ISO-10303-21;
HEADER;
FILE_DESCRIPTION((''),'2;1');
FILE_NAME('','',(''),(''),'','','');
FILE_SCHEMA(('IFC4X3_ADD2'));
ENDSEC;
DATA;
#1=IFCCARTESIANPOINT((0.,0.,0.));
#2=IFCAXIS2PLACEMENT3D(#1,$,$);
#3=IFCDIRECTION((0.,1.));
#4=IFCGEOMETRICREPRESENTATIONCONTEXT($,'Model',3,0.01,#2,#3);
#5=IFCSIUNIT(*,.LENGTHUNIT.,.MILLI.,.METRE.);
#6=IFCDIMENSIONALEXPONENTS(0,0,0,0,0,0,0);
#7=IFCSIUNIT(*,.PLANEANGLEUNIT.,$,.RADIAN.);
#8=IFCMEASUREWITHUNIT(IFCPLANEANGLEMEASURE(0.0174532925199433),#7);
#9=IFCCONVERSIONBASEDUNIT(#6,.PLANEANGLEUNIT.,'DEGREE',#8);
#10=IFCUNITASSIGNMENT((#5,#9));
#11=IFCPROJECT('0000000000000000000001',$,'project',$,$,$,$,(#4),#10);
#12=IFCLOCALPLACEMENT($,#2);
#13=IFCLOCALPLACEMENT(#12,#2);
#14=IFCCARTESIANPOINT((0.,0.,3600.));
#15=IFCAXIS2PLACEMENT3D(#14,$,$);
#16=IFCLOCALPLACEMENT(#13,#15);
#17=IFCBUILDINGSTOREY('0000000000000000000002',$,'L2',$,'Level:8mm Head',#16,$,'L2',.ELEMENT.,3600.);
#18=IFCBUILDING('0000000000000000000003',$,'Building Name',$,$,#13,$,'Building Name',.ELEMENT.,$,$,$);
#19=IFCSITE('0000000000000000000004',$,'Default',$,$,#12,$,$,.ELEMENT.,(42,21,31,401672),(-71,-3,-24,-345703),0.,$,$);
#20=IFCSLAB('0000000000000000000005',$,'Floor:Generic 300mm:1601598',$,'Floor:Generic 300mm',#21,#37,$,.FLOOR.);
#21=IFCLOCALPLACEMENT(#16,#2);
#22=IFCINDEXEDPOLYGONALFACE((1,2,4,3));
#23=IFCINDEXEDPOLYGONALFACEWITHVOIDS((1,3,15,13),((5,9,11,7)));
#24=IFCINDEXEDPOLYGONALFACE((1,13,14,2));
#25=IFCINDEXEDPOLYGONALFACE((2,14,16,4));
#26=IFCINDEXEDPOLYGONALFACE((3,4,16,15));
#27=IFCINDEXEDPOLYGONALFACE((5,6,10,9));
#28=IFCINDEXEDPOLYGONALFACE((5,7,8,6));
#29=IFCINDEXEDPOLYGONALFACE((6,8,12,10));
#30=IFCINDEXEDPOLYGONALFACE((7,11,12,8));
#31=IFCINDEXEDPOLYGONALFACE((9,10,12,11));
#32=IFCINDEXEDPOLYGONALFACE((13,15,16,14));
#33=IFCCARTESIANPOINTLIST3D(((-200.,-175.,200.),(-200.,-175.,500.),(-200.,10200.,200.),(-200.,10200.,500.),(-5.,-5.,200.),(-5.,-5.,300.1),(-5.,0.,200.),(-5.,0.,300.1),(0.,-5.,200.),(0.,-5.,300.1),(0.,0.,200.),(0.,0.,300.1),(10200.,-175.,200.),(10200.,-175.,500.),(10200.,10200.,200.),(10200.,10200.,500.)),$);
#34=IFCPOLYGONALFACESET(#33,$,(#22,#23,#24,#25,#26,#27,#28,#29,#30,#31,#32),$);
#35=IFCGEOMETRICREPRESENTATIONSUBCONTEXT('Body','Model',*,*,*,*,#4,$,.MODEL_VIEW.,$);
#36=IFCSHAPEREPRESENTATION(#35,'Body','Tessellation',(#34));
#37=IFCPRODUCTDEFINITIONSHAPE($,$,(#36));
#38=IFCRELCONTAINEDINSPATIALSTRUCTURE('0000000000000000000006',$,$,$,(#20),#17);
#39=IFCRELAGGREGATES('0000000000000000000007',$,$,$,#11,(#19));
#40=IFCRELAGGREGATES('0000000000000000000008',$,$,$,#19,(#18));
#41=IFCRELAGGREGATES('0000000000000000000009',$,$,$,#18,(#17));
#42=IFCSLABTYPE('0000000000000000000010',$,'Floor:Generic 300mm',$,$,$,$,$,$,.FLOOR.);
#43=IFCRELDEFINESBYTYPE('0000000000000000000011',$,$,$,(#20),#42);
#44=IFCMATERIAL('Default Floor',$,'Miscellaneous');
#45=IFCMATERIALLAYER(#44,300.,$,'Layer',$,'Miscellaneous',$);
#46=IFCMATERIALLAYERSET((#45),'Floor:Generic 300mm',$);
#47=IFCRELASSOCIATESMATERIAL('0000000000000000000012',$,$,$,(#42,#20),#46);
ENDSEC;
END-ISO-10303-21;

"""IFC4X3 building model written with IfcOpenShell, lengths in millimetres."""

from ifc_helpers import new_model, entity, si_unit, converted_unit, direction, frame, frame_2d, origin, place, context, subcontext, project, spatial, rectangle, extrude, material, layer, layer_set, layer_usage, type_object, element, save


model = new_model("IFC4X3")

# Units and contexts
model_context = context("Model", 3, precision=0.01, world=origin(), true_north=direction((0.0, 1.0)))
body_context = subcontext(model_context, "Body", "Model", "MODEL_VIEW")
ifc_project = project(units=[si_unit("LENGTHUNIT", "METRE", prefix="MILLI"), converted_unit("PLANEANGLEUNIT", "DEGREE", entity("IfcPlaneAngleMeasure", 0.0174532925199433), si_unit("PLANEANGLEUNIT", "RADIAN"), dimensions=[0, 0, 0, 0, 0, 0, 0])], contexts=[model_context])

# Site, building, storey
site_placement = place(None, origin())
site = spatial("IfcSite", under=ifc_project, at=site_placement, Name="Default", CompositionType="ELEMENT", RefLatitude=(42, 21, 31, 401672), RefLongitude=(-71, -3, -24, -345703), RefElevation=0.0)
building_placement = place(site_placement, origin())
building = spatial("IfcBuilding", under=site, at=building_placement, Name="Building Name", LongName="Building Name", CompositionType="ELEMENT")
storey_placement = place(building_placement, frame((0.0, 0.0, 3600.0)))
storey = spatial("IfcBuildingStorey", under=building, at=storey_placement, Name="L2", ObjectType="Level:8mm Head", LongName="L2", CompositionType="ELEMENT", Elevation=3600.0)

# Slab, opening
ifc_material = material(Name="Default Floor", Category="Miscellaneous")
ifc_layer = layer(ifc_material, 300.0, Name="Layer", Category="Miscellaneous")
ifc_layer_set = layer_set([ifc_layer], Name="Floor:Generic 300mm")
ifc_layer_usage = layer_usage(ifc_layer_set, "AXIS3", "POSITIVE", 0.0)
slab_type = type_object("IfcSlabType", Name="Floor:Generic 300mm", PredefinedType="FLOOR", material=ifc_layer_set)
slab_placement = place(storey_placement, origin())
slab = element("IfcSlab", 1, at=slab_placement, inside=storey, type_object=slab_type, material=ifc_layer_usage, Name="Floor:Generic 300mm:1601598", ObjectType="Floor:Generic 300mm", PredefinedType="FLOOR", context=body_context, shape_type="SweptSolid", body=[
    extrude(rectangle(XDim=10375.0, YDim=10400.0, at=frame_2d((0.0, 0.0), x_axis=(1.0, 0.0))), frame((5000.0, 5012.5, 500.0), z_axis=(0.0, 0.0, -1.0), x_axis=(0.0, 1.0, 0.0)), (0.0, 0.0, 1.0), 300.0),
])
opening_placement = place(slab_placement, origin())
element("IfcOpeningElement", 2, at=opening_placement, cuts=slab, context=model_context, shape_type="SweptSolid", body=[
    extrude(rectangle(XDim=5.0, YDim=5.0, at=frame_2d((-2.5, -2.5))), frame((0.0, 0.0, -0.1)), (0.0, 0.0, 1.0), 300.2),
])

save(model, "model.ifc")
